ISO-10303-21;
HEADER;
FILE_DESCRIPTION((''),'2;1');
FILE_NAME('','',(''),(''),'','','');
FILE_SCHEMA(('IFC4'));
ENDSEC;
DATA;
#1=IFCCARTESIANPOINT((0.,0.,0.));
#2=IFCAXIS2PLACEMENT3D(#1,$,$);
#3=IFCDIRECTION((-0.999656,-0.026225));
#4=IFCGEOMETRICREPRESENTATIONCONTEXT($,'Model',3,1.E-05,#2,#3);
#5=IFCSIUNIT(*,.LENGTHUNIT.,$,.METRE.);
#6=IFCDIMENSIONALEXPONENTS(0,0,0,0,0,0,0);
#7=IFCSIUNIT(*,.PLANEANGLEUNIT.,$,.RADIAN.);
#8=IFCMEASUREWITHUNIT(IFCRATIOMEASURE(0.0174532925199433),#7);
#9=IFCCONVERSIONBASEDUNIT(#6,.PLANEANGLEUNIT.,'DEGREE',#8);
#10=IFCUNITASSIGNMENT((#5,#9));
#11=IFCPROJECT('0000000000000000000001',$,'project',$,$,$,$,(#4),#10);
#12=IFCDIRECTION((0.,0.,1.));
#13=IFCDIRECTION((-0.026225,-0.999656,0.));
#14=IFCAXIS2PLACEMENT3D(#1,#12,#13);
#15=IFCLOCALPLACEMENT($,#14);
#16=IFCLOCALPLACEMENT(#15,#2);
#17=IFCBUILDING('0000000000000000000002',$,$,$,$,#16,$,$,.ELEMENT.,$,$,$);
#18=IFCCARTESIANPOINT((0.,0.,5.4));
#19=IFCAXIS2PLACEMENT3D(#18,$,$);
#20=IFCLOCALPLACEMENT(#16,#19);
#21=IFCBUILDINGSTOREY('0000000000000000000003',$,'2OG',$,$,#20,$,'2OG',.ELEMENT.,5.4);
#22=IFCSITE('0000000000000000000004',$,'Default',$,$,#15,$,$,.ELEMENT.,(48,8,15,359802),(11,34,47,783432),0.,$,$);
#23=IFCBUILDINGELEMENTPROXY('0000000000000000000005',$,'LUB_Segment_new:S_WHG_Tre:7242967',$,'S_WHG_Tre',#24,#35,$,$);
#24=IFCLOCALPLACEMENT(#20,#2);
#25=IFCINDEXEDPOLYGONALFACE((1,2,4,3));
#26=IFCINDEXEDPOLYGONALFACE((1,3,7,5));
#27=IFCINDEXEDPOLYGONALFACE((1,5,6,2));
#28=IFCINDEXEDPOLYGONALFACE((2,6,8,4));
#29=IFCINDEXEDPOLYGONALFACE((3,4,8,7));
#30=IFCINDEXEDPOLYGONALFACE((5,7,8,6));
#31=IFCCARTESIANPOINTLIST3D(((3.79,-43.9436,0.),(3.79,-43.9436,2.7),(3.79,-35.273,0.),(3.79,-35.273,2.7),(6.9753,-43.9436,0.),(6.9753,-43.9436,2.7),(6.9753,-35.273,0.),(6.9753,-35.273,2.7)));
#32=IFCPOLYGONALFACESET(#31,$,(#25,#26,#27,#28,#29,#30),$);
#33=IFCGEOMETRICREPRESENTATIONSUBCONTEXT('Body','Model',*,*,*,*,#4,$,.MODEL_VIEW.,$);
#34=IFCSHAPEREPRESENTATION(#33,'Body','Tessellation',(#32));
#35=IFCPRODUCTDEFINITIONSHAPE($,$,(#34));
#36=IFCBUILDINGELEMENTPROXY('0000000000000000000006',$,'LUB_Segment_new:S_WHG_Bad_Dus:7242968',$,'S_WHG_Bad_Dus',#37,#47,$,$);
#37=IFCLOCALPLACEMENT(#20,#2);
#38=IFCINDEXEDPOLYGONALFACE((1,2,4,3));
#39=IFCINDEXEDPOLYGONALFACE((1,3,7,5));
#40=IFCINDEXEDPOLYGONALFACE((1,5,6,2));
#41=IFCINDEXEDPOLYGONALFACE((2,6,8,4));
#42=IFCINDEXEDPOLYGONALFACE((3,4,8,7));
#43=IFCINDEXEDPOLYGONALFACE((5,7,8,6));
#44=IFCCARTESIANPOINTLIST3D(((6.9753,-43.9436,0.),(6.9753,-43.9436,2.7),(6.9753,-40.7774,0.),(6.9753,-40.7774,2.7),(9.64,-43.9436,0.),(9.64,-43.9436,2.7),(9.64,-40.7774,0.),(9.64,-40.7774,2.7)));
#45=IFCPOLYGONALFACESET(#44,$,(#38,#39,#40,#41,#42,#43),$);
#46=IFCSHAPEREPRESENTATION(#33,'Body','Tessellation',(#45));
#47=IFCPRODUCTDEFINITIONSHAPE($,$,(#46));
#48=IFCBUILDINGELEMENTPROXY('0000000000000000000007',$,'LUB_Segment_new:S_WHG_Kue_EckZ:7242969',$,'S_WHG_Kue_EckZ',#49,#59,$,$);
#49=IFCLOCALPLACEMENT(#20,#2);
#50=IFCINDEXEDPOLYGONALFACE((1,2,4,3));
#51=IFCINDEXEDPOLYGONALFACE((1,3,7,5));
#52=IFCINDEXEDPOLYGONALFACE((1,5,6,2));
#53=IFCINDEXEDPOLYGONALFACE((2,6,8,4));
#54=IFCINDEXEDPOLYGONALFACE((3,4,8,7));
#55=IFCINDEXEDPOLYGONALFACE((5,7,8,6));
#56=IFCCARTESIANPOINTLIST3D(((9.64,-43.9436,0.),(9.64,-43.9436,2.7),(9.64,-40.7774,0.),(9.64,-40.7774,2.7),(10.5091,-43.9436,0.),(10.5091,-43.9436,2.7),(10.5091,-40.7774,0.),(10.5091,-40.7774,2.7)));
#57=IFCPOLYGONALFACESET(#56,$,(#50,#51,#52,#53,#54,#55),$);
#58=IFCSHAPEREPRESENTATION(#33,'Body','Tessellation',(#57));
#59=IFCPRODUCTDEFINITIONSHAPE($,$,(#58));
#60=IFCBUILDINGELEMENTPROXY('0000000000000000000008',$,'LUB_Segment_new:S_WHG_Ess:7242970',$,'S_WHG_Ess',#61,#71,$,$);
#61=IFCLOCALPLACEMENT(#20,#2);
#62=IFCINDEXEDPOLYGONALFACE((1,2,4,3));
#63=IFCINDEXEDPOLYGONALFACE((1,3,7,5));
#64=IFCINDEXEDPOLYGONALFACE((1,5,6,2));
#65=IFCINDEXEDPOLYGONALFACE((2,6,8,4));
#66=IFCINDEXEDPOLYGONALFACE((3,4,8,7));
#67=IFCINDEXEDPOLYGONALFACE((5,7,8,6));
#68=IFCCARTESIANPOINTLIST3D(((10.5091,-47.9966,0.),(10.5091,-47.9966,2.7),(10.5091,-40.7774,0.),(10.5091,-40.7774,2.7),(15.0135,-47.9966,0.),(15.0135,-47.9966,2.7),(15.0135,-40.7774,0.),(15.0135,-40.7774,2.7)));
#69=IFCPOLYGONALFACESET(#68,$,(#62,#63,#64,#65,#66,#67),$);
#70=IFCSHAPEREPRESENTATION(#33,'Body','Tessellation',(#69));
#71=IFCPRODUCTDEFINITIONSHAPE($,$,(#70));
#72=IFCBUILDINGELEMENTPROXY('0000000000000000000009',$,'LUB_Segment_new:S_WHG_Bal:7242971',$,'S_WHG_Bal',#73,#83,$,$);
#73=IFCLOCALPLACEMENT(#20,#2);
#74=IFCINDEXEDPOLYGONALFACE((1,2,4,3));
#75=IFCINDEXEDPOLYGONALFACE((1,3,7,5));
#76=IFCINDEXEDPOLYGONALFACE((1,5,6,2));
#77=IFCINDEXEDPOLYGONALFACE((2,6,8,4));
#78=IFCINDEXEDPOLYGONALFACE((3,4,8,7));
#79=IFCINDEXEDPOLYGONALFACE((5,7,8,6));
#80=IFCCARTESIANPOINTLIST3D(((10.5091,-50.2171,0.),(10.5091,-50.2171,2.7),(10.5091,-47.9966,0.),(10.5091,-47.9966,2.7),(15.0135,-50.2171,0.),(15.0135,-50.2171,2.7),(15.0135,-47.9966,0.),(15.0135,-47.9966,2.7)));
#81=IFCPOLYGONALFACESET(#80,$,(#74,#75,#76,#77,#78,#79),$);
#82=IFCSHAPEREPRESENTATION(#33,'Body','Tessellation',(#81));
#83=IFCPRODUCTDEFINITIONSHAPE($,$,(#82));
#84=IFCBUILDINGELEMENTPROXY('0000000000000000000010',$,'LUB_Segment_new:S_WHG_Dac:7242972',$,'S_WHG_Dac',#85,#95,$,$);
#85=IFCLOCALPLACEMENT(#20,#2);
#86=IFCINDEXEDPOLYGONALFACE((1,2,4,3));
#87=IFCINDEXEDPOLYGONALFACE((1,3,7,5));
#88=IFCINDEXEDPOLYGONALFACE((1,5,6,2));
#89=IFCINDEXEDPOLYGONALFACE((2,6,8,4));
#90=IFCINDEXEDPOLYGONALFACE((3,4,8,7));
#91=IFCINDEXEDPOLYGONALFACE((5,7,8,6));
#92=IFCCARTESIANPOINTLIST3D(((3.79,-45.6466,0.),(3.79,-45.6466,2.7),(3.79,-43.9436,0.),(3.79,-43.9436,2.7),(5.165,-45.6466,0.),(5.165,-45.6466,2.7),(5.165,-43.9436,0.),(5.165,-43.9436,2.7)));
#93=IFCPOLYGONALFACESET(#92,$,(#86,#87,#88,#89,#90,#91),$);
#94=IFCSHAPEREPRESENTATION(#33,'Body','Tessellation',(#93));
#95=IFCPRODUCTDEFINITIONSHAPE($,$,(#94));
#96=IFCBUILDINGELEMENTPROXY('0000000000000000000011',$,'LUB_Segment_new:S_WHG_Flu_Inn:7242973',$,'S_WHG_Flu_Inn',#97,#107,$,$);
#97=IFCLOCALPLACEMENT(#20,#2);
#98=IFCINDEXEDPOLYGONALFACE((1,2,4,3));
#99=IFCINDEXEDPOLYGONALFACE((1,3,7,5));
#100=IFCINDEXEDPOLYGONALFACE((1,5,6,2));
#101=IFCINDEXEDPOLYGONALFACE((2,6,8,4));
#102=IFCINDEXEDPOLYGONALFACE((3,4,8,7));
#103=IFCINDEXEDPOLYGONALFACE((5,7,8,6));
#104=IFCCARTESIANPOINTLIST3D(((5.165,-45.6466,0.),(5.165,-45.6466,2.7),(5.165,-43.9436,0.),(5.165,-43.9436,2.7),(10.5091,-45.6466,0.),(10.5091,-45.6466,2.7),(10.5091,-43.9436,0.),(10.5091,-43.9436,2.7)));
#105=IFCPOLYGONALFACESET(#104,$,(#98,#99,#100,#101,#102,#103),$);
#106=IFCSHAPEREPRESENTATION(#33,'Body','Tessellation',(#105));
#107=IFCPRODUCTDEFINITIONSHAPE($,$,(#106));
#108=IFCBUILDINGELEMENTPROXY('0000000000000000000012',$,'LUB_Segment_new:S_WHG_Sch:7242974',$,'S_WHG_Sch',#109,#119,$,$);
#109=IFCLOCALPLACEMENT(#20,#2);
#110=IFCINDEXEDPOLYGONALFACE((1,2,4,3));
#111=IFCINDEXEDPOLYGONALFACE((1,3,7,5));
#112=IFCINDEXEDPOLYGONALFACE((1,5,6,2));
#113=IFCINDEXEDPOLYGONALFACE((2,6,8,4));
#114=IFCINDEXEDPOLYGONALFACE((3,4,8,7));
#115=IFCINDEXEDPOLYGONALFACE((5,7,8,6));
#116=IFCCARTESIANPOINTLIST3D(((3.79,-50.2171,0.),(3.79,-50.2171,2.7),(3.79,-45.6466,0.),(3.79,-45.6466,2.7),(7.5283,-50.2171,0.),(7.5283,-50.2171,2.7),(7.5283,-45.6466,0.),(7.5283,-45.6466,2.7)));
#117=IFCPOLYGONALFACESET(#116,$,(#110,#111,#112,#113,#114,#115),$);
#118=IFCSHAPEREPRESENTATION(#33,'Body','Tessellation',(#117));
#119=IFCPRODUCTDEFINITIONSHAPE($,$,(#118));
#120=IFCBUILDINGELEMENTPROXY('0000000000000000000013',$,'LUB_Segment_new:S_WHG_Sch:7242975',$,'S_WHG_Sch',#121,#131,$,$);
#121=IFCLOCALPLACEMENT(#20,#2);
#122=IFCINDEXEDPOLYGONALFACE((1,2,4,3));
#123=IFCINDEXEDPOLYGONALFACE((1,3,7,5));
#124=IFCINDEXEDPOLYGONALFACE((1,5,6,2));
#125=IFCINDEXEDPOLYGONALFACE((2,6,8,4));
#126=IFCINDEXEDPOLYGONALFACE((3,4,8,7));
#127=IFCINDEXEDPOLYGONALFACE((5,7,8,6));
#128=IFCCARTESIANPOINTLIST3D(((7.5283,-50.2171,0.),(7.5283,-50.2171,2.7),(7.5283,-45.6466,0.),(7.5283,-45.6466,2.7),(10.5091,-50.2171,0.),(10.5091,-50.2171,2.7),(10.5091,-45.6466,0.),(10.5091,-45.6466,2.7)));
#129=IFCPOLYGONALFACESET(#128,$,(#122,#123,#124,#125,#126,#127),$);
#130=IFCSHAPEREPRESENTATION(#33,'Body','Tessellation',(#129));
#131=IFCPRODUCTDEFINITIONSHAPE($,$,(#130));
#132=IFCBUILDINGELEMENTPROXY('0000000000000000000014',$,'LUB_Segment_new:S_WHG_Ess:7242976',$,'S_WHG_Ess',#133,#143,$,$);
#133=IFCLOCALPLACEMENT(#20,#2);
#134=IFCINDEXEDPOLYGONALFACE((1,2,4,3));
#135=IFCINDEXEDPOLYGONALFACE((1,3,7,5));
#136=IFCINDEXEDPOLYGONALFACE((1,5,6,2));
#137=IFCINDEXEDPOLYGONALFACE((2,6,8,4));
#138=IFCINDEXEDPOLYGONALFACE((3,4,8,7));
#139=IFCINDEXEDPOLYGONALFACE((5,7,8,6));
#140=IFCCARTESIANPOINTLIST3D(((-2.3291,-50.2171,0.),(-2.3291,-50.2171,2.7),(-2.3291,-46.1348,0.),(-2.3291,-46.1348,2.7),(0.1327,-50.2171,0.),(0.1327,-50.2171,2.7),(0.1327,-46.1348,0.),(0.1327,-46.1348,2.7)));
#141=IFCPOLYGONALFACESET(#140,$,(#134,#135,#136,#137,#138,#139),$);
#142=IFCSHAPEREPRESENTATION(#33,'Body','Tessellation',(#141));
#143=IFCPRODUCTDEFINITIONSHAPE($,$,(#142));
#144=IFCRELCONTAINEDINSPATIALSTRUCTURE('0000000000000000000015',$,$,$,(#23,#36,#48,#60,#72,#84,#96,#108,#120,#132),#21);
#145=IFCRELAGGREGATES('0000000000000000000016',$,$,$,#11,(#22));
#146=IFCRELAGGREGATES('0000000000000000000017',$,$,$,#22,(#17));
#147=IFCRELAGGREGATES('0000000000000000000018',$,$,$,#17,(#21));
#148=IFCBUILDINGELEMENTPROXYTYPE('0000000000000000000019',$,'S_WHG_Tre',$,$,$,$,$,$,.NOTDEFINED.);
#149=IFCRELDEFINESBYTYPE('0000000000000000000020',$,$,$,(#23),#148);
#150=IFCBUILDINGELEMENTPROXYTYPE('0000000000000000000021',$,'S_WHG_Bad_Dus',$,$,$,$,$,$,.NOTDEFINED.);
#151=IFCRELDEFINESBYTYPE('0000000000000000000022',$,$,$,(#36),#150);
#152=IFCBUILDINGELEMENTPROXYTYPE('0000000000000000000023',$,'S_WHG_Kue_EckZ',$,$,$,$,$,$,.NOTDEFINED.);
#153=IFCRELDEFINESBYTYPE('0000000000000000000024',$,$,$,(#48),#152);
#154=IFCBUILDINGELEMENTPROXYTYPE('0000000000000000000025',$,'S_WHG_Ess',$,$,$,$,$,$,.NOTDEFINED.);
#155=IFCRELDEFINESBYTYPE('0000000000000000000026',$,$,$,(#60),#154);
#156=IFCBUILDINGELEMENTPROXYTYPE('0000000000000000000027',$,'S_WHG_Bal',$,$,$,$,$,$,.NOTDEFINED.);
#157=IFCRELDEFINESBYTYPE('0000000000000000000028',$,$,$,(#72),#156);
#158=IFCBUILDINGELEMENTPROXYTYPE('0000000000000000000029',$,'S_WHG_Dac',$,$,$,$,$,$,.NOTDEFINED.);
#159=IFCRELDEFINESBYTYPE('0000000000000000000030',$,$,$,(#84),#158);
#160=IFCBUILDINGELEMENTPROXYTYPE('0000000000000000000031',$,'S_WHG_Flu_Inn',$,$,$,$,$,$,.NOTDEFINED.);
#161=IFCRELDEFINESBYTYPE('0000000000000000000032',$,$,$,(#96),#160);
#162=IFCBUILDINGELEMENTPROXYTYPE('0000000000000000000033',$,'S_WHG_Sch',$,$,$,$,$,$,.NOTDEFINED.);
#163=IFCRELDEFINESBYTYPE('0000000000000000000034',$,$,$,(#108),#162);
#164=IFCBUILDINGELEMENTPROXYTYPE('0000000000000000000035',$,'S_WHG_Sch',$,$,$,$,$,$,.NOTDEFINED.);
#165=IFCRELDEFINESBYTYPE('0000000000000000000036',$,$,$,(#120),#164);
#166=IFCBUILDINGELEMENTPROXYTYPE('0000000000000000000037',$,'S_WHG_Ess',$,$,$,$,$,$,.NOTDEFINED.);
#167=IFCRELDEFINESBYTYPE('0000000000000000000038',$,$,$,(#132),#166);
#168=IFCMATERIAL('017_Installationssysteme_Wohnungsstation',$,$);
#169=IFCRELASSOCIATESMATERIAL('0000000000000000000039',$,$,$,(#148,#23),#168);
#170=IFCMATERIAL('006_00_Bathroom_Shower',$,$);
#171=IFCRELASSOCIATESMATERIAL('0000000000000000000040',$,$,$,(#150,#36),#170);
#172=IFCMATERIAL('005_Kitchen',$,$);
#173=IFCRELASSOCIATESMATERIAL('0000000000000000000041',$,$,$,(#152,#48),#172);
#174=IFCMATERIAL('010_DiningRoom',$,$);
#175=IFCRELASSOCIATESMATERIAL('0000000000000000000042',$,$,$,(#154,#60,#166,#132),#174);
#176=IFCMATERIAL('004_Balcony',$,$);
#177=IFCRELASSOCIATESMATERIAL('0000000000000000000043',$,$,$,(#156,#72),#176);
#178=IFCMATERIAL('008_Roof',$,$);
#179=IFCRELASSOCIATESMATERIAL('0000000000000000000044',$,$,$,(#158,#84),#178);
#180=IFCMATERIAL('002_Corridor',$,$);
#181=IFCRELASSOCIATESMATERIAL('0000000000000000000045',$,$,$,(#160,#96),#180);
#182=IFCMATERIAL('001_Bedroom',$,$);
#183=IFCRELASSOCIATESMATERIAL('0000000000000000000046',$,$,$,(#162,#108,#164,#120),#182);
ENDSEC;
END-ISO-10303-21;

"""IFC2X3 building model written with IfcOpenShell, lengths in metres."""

from ifc_helpers import new_model, entity, si_unit, converted_unit, direction, frame, frame_2d, origin, origin_2d_with_axis, place, context, subcontext, project, spatial, rectangle, extrude, source, transform, mapped, material, type_object, type_shapes, element, save


model = new_model("IFC2X3")

# Units and contexts
model_context = context("Model", 3, precision=1e-05, world=origin(), true_north=direction((-0.999656, -0.026225)))
body_context = subcontext(model_context, "Body", "Model", "MODEL_VIEW")
ifc_project = project(units=[si_unit("LENGTHUNIT", "METRE"), converted_unit("PLANEANGLEUNIT", "DEGREE", entity("IfcRatioMeasure", 0.0174532925199433), si_unit("PLANEANGLEUNIT", "RADIAN"), dimensions=[0, 0, 0, 0, 0, 0, 0])], contexts=[model_context])

# Site, building, storey
site_placement = place(None, frame((0.0, 0.0, 0.0), z_axis=(0.0, 0.0, 1.0), x_axis=(-0.026225, -0.999656, 0.0)))
site = spatial("IfcSite", under=ifc_project, at=site_placement, Name="Default", CompositionType="ELEMENT", RefLatitude=(48, 8, 15, 359802), RefLongitude=(11, 34, 47, 783432), RefElevation=0.0)
building_placement = place(site_placement, origin())
building = spatial("IfcBuilding", under=site, at=building_placement, CompositionType="ELEMENT")
storey_placement = place(building_placement, frame((0.0, 0.0, 5.4)))
storey = spatial("IfcBuildingStorey", under=building, at=storey_placement, Name="2OG", LongName="2OG", CompositionType="ELEMENT", Elevation=5.4)

# Building element proxies
ifc_material_1 = material(Name="001_Bedroom")
ifc_material_2 = material(Name="010_DiningRoom")
ifc_material_3 = material(Name="004_Balcony")
ifc_material_4 = material(Name="005_Kitchen")
ifc_material_5 = material(Name="002_Corridor")
ifc_material_6 = material(Name="008_Roof")
ifc_material_7 = material(Name="006_00_Bathroom_Shower")
ifc_material_8 = material(Name="017_Installationssysteme_Wohnungsstation")
building_element_proxy_type_1 = type_object("IfcBuildingElementProxyType", Name="S_WHG_Tre", PredefinedType="NOTDEFINED", material=ifc_material_8)
shared_shape_1 = source(origin(), body_context, "Body", "SweptSolid", [
    extrude(rectangle(XDim=3.1853, YDim=8.6706, at=frame_2d((0.0, 0.0), x_axis=(1.0, 0.0))), frame((0.0, 0.0, 0.0), z_axis=(0.0, 0.0, 1.0), x_axis=(-1.0, 0.0, 0.0)), (0.0, 0.0, 1.0), 2.7),
])
type_shapes(building_element_proxy_type_1, [shared_shape_1])
proxy_1_placement = place(storey_placement, frame((5.3827, -39.6083, 0.0)))
element("IfcBuildingElementProxy", 1, at=proxy_1_placement, inside=storey, type_object=building_element_proxy_type_1, material=ifc_material_8, Name="LUB_Segment_new:S_WHG_Tre:7242967", ObjectType="S_WHG_Tre", context=body_context, shape_type="MappedRepresentation", body=[
    mapped(shared_shape_1, transform((0.0, 0.0, 0.0), scale=1.0)),
])
building_element_proxy_type_2 = type_object("IfcBuildingElementProxyType", Name="S_WHG_Bad_Dus", PredefinedType="NOTDEFINED", material=ifc_material_7)
shared_shape_2 = source(origin(), body_context, "Body", "SweptSolid", [
    extrude(rectangle(XDim=3.1662, YDim=2.6647, at=origin_2d_with_axis()), frame((0.0, 0.0, 0.0), z_axis=(0.0, 0.0, 1.0), x_axis=(0.0, 1.0, 0.0)), (0.0, 0.0, 1.0), 2.7),
])
type_shapes(building_element_proxy_type_2, [shared_shape_2])
proxy_2_placement = place(storey_placement, frame((8.3077, -42.3605, 0.0)))
element("IfcBuildingElementProxy", 2, at=proxy_2_placement, inside=storey, type_object=building_element_proxy_type_2, material=ifc_material_7, Name="LUB_Segment_new:S_WHG_Bad_Dus:7242968", ObjectType="S_WHG_Bad_Dus", context=body_context, shape_type="MappedRepresentation", body=[
    mapped(shared_shape_2, transform((0.0, 0.0, 0.0), scale=1.0)),
])
building_element_proxy_type_3 = type_object("IfcBuildingElementProxyType", Name="S_WHG_Kue_EckZ", PredefinedType="NOTDEFINED", material=ifc_material_4)
shared_shape_3 = source(origin(), body_context, "Body", "SweptSolid", [
    extrude(rectangle(XDim=3.1662, YDim=0.8691, at=origin_2d_with_axis()), frame((0.0, 0.0, 0.0), z_axis=(0.0, 0.0, 1.0), x_axis=(0.0, 1.0, 0.0)), (0.0, 0.0, 1.0), 2.7),
])
type_shapes(building_element_proxy_type_3, [shared_shape_3])
proxy_3_placement = place(storey_placement, frame((10.0746, -42.3605, 0.0)))
element("IfcBuildingElementProxy", 3, at=proxy_3_placement, inside=storey, type_object=building_element_proxy_type_3, material=ifc_material_4, Name="LUB_Segment_new:S_WHG_Kue_EckZ:7242969", ObjectType="S_WHG_Kue_EckZ", context=body_context, shape_type="MappedRepresentation", body=[
    mapped(shared_shape_3, transform((0.0, 0.0, 0.0), scale=1.0)),
])
building_element_proxy_type_4 = type_object("IfcBuildingElementProxyType", Name="S_WHG_Ess", PredefinedType="NOTDEFINED", material=ifc_material_2)
shared_shape_4 = source(origin(), body_context, "Body", "SweptSolid", [
    extrude(rectangle(XDim=4.5044, YDim=7.2191, at=origin_2d_with_axis()), frame((0.0, 0.0, 0.0), z_axis=(0.0, 0.0, 1.0), x_axis=(-1.0, 0.0, 0.0)), (0.0, 0.0, 1.0), 2.7),
])
type_shapes(building_element_proxy_type_4, [shared_shape_4])
proxy_4_placement = place(storey_placement, frame((12.7613, -44.387, 0.0)))
element("IfcBuildingElementProxy", 4, at=proxy_4_placement, inside=storey, type_object=building_element_proxy_type_4, material=ifc_material_2, Name="LUB_Segment_new:S_WHG_Ess:7242970", ObjectType="S_WHG_Ess", context=body_context, shape_type="MappedRepresentation", body=[
    mapped(shared_shape_4, transform((0.0, 0.0, 0.0), scale=1.0)),
])
building_element_proxy_type_5 = type_object("IfcBuildingElementProxyType", Name="S_WHG_Bal", PredefinedType="NOTDEFINED", material=ifc_material_3)
shared_shape_5 = source(origin(), body_context, "Body", "SweptSolid", [
    extrude(rectangle(XDim=2.2206, YDim=4.5044, at=origin_2d_with_axis()), frame((0.0, 0.0, 0.0), z_axis=(0.0, 0.0, 1.0), x_axis=(0.0, 1.0, 0.0)), (0.0, 0.0, 1.0), 2.7),
])
type_shapes(building_element_proxy_type_5, [shared_shape_5])
proxy_5_placement = place(storey_placement, frame((12.7613, -49.1068, 0.0)))
element("IfcBuildingElementProxy", 5, at=proxy_5_placement, inside=storey, type_object=building_element_proxy_type_5, material=ifc_material_3, Name="LUB_Segment_new:S_WHG_Bal:7242971", ObjectType="S_WHG_Bal", context=body_context, shape_type="MappedRepresentation", body=[
    mapped(shared_shape_5, transform((0.0, 0.0, 0.0), scale=1.0)),
])
building_element_proxy_type_6 = type_object("IfcBuildingElementProxyType", Name="S_WHG_Dac", PredefinedType="NOTDEFINED", material=ifc_material_6)
shared_shape_6 = source(origin(), body_context, "Body", "SweptSolid", [
    extrude(rectangle(XDim=1.7029, YDim=1.375, at=origin_2d_with_axis()), frame((0.0, 0.0, 0.0), z_axis=(0.0, 0.0, 1.0), x_axis=(0.0, 1.0, 0.0)), (0.0, 0.0, 1.0), 2.7),
])
type_shapes(building_element_proxy_type_6, [shared_shape_6])
proxy_6_placement = place(storey_placement, frame((4.4775, -44.7951, 0.0)))
element("IfcBuildingElementProxy", 6, at=proxy_6_placement, inside=storey, type_object=building_element_proxy_type_6, material=ifc_material_6, Name="LUB_Segment_new:S_WHG_Dac:7242972", ObjectType="S_WHG_Dac", context=body_context, shape_type="MappedRepresentation", body=[
    mapped(shared_shape_6, transform((0.0, 0.0, 0.0), scale=1.0)),
])
building_element_proxy_type_7 = type_object("IfcBuildingElementProxyType", Name="S_WHG_Flu_Inn", PredefinedType="NOTDEFINED", material=ifc_material_5)
shared_shape_7 = source(origin(), body_context, "Body", "SweptSolid", [
    extrude(rectangle(XDim=1.7029, YDim=5.3441, at=origin_2d_with_axis()), frame((0.0, 0.0, 0.0), z_axis=(0.0, 0.0, 1.0), x_axis=(0.0, 1.0, 0.0)), (0.0, 0.0, 1.0), 2.7),
])
type_shapes(building_element_proxy_type_7, [shared_shape_7])
proxy_7_placement = place(storey_placement, frame((7.8371, -44.7951, 0.0)))
element("IfcBuildingElementProxy", 7, at=proxy_7_placement, inside=storey, type_object=building_element_proxy_type_7, material=ifc_material_5, Name="LUB_Segment_new:S_WHG_Flu_Inn:7242973", ObjectType="S_WHG_Flu_Inn", context=body_context, shape_type="MappedRepresentation", body=[
    mapped(shared_shape_7, transform((0.0, 0.0, 0.0), scale=1.0)),
])
building_element_proxy_type_8 = type_object("IfcBuildingElementProxyType", Name="S_WHG_Sch", PredefinedType="NOTDEFINED", material=ifc_material_1)
shared_shape_8 = source(origin(), body_context, "Body", "SweptSolid", [
    extrude(rectangle(XDim=3.7382, YDim=4.5706, at=origin_2d_with_axis()), frame((0.0, 0.0, 0.0), z_axis=(0.0, 0.0, 1.0), x_axis=(-1.0, 0.0, 0.0)), (0.0, 0.0, 1.0), 2.7),
])
type_shapes(building_element_proxy_type_8, [shared_shape_8])
proxy_8_placement = place(storey_placement, frame((5.6591, -47.9318, 0.0)))
element("IfcBuildingElementProxy", 8, at=proxy_8_placement, inside=storey, type_object=building_element_proxy_type_8, material=ifc_material_1, Name="LUB_Segment_new:S_WHG_Sch:7242974", ObjectType="S_WHG_Sch", context=body_context, shape_type="MappedRepresentation", body=[
    mapped(shared_shape_8, transform((0.0, 0.0, 0.0), scale=1.0)),
])
building_element_proxy_type_9 = type_object("IfcBuildingElementProxyType", Name="S_WHG_Sch", PredefinedType="NOTDEFINED", material=ifc_material_1)
shared_shape_9 = source(origin(), body_context, "Body", "SweptSolid", [
    extrude(rectangle(XDim=2.9809, YDim=4.5706, at=origin_2d_with_axis()), frame((0.0, 0.0, 0.0), z_axis=(0.0, 0.0, 1.0), x_axis=(-1.0, 0.0, 0.0)), (0.0, 0.0, 1.0), 2.7),
])
type_shapes(building_element_proxy_type_9, [shared_shape_9])
proxy_9_placement = place(storey_placement, frame((9.0187, -47.9318, 0.0)))
element("IfcBuildingElementProxy", 9, at=proxy_9_placement, inside=storey, type_object=building_element_proxy_type_9, material=ifc_material_1, Name="LUB_Segment_new:S_WHG_Sch:7242975", ObjectType="S_WHG_Sch", context=body_context, shape_type="MappedRepresentation", body=[
    mapped(shared_shape_9, transform((0.0, 0.0, 0.0), scale=1.0)),
])
building_element_proxy_type_10 = type_object("IfcBuildingElementProxyType", Name="S_WHG_Ess", PredefinedType="NOTDEFINED", material=ifc_material_2)
shared_shape_10 = source(origin(), body_context, "Body", "SweptSolid", [
    extrude(rectangle(XDim=4.0824, YDim=2.4618, at=origin_2d_with_axis()), frame((0.0, 0.0, 0.0), z_axis=(0.0, 0.0, 1.0), x_axis=(0.0, 1.0, 0.0)), (0.0, 0.0, 1.0), 2.7),
])
type_shapes(building_element_proxy_type_10, [shared_shape_10])
proxy_10_placement = place(storey_placement, frame((-1.0982, -48.176, 0.0)))
element("IfcBuildingElementProxy", 10, at=proxy_10_placement, inside=storey, type_object=building_element_proxy_type_10, material=ifc_material_2, Name="LUB_Segment_new:S_WHG_Ess:7242976", ObjectType="S_WHG_Ess", context=body_context, shape_type="MappedRepresentation", body=[
    mapped(shared_shape_10, transform((0.0, 0.0, 0.0), scale=1.0)),
])

save(model, "model.ifc")
